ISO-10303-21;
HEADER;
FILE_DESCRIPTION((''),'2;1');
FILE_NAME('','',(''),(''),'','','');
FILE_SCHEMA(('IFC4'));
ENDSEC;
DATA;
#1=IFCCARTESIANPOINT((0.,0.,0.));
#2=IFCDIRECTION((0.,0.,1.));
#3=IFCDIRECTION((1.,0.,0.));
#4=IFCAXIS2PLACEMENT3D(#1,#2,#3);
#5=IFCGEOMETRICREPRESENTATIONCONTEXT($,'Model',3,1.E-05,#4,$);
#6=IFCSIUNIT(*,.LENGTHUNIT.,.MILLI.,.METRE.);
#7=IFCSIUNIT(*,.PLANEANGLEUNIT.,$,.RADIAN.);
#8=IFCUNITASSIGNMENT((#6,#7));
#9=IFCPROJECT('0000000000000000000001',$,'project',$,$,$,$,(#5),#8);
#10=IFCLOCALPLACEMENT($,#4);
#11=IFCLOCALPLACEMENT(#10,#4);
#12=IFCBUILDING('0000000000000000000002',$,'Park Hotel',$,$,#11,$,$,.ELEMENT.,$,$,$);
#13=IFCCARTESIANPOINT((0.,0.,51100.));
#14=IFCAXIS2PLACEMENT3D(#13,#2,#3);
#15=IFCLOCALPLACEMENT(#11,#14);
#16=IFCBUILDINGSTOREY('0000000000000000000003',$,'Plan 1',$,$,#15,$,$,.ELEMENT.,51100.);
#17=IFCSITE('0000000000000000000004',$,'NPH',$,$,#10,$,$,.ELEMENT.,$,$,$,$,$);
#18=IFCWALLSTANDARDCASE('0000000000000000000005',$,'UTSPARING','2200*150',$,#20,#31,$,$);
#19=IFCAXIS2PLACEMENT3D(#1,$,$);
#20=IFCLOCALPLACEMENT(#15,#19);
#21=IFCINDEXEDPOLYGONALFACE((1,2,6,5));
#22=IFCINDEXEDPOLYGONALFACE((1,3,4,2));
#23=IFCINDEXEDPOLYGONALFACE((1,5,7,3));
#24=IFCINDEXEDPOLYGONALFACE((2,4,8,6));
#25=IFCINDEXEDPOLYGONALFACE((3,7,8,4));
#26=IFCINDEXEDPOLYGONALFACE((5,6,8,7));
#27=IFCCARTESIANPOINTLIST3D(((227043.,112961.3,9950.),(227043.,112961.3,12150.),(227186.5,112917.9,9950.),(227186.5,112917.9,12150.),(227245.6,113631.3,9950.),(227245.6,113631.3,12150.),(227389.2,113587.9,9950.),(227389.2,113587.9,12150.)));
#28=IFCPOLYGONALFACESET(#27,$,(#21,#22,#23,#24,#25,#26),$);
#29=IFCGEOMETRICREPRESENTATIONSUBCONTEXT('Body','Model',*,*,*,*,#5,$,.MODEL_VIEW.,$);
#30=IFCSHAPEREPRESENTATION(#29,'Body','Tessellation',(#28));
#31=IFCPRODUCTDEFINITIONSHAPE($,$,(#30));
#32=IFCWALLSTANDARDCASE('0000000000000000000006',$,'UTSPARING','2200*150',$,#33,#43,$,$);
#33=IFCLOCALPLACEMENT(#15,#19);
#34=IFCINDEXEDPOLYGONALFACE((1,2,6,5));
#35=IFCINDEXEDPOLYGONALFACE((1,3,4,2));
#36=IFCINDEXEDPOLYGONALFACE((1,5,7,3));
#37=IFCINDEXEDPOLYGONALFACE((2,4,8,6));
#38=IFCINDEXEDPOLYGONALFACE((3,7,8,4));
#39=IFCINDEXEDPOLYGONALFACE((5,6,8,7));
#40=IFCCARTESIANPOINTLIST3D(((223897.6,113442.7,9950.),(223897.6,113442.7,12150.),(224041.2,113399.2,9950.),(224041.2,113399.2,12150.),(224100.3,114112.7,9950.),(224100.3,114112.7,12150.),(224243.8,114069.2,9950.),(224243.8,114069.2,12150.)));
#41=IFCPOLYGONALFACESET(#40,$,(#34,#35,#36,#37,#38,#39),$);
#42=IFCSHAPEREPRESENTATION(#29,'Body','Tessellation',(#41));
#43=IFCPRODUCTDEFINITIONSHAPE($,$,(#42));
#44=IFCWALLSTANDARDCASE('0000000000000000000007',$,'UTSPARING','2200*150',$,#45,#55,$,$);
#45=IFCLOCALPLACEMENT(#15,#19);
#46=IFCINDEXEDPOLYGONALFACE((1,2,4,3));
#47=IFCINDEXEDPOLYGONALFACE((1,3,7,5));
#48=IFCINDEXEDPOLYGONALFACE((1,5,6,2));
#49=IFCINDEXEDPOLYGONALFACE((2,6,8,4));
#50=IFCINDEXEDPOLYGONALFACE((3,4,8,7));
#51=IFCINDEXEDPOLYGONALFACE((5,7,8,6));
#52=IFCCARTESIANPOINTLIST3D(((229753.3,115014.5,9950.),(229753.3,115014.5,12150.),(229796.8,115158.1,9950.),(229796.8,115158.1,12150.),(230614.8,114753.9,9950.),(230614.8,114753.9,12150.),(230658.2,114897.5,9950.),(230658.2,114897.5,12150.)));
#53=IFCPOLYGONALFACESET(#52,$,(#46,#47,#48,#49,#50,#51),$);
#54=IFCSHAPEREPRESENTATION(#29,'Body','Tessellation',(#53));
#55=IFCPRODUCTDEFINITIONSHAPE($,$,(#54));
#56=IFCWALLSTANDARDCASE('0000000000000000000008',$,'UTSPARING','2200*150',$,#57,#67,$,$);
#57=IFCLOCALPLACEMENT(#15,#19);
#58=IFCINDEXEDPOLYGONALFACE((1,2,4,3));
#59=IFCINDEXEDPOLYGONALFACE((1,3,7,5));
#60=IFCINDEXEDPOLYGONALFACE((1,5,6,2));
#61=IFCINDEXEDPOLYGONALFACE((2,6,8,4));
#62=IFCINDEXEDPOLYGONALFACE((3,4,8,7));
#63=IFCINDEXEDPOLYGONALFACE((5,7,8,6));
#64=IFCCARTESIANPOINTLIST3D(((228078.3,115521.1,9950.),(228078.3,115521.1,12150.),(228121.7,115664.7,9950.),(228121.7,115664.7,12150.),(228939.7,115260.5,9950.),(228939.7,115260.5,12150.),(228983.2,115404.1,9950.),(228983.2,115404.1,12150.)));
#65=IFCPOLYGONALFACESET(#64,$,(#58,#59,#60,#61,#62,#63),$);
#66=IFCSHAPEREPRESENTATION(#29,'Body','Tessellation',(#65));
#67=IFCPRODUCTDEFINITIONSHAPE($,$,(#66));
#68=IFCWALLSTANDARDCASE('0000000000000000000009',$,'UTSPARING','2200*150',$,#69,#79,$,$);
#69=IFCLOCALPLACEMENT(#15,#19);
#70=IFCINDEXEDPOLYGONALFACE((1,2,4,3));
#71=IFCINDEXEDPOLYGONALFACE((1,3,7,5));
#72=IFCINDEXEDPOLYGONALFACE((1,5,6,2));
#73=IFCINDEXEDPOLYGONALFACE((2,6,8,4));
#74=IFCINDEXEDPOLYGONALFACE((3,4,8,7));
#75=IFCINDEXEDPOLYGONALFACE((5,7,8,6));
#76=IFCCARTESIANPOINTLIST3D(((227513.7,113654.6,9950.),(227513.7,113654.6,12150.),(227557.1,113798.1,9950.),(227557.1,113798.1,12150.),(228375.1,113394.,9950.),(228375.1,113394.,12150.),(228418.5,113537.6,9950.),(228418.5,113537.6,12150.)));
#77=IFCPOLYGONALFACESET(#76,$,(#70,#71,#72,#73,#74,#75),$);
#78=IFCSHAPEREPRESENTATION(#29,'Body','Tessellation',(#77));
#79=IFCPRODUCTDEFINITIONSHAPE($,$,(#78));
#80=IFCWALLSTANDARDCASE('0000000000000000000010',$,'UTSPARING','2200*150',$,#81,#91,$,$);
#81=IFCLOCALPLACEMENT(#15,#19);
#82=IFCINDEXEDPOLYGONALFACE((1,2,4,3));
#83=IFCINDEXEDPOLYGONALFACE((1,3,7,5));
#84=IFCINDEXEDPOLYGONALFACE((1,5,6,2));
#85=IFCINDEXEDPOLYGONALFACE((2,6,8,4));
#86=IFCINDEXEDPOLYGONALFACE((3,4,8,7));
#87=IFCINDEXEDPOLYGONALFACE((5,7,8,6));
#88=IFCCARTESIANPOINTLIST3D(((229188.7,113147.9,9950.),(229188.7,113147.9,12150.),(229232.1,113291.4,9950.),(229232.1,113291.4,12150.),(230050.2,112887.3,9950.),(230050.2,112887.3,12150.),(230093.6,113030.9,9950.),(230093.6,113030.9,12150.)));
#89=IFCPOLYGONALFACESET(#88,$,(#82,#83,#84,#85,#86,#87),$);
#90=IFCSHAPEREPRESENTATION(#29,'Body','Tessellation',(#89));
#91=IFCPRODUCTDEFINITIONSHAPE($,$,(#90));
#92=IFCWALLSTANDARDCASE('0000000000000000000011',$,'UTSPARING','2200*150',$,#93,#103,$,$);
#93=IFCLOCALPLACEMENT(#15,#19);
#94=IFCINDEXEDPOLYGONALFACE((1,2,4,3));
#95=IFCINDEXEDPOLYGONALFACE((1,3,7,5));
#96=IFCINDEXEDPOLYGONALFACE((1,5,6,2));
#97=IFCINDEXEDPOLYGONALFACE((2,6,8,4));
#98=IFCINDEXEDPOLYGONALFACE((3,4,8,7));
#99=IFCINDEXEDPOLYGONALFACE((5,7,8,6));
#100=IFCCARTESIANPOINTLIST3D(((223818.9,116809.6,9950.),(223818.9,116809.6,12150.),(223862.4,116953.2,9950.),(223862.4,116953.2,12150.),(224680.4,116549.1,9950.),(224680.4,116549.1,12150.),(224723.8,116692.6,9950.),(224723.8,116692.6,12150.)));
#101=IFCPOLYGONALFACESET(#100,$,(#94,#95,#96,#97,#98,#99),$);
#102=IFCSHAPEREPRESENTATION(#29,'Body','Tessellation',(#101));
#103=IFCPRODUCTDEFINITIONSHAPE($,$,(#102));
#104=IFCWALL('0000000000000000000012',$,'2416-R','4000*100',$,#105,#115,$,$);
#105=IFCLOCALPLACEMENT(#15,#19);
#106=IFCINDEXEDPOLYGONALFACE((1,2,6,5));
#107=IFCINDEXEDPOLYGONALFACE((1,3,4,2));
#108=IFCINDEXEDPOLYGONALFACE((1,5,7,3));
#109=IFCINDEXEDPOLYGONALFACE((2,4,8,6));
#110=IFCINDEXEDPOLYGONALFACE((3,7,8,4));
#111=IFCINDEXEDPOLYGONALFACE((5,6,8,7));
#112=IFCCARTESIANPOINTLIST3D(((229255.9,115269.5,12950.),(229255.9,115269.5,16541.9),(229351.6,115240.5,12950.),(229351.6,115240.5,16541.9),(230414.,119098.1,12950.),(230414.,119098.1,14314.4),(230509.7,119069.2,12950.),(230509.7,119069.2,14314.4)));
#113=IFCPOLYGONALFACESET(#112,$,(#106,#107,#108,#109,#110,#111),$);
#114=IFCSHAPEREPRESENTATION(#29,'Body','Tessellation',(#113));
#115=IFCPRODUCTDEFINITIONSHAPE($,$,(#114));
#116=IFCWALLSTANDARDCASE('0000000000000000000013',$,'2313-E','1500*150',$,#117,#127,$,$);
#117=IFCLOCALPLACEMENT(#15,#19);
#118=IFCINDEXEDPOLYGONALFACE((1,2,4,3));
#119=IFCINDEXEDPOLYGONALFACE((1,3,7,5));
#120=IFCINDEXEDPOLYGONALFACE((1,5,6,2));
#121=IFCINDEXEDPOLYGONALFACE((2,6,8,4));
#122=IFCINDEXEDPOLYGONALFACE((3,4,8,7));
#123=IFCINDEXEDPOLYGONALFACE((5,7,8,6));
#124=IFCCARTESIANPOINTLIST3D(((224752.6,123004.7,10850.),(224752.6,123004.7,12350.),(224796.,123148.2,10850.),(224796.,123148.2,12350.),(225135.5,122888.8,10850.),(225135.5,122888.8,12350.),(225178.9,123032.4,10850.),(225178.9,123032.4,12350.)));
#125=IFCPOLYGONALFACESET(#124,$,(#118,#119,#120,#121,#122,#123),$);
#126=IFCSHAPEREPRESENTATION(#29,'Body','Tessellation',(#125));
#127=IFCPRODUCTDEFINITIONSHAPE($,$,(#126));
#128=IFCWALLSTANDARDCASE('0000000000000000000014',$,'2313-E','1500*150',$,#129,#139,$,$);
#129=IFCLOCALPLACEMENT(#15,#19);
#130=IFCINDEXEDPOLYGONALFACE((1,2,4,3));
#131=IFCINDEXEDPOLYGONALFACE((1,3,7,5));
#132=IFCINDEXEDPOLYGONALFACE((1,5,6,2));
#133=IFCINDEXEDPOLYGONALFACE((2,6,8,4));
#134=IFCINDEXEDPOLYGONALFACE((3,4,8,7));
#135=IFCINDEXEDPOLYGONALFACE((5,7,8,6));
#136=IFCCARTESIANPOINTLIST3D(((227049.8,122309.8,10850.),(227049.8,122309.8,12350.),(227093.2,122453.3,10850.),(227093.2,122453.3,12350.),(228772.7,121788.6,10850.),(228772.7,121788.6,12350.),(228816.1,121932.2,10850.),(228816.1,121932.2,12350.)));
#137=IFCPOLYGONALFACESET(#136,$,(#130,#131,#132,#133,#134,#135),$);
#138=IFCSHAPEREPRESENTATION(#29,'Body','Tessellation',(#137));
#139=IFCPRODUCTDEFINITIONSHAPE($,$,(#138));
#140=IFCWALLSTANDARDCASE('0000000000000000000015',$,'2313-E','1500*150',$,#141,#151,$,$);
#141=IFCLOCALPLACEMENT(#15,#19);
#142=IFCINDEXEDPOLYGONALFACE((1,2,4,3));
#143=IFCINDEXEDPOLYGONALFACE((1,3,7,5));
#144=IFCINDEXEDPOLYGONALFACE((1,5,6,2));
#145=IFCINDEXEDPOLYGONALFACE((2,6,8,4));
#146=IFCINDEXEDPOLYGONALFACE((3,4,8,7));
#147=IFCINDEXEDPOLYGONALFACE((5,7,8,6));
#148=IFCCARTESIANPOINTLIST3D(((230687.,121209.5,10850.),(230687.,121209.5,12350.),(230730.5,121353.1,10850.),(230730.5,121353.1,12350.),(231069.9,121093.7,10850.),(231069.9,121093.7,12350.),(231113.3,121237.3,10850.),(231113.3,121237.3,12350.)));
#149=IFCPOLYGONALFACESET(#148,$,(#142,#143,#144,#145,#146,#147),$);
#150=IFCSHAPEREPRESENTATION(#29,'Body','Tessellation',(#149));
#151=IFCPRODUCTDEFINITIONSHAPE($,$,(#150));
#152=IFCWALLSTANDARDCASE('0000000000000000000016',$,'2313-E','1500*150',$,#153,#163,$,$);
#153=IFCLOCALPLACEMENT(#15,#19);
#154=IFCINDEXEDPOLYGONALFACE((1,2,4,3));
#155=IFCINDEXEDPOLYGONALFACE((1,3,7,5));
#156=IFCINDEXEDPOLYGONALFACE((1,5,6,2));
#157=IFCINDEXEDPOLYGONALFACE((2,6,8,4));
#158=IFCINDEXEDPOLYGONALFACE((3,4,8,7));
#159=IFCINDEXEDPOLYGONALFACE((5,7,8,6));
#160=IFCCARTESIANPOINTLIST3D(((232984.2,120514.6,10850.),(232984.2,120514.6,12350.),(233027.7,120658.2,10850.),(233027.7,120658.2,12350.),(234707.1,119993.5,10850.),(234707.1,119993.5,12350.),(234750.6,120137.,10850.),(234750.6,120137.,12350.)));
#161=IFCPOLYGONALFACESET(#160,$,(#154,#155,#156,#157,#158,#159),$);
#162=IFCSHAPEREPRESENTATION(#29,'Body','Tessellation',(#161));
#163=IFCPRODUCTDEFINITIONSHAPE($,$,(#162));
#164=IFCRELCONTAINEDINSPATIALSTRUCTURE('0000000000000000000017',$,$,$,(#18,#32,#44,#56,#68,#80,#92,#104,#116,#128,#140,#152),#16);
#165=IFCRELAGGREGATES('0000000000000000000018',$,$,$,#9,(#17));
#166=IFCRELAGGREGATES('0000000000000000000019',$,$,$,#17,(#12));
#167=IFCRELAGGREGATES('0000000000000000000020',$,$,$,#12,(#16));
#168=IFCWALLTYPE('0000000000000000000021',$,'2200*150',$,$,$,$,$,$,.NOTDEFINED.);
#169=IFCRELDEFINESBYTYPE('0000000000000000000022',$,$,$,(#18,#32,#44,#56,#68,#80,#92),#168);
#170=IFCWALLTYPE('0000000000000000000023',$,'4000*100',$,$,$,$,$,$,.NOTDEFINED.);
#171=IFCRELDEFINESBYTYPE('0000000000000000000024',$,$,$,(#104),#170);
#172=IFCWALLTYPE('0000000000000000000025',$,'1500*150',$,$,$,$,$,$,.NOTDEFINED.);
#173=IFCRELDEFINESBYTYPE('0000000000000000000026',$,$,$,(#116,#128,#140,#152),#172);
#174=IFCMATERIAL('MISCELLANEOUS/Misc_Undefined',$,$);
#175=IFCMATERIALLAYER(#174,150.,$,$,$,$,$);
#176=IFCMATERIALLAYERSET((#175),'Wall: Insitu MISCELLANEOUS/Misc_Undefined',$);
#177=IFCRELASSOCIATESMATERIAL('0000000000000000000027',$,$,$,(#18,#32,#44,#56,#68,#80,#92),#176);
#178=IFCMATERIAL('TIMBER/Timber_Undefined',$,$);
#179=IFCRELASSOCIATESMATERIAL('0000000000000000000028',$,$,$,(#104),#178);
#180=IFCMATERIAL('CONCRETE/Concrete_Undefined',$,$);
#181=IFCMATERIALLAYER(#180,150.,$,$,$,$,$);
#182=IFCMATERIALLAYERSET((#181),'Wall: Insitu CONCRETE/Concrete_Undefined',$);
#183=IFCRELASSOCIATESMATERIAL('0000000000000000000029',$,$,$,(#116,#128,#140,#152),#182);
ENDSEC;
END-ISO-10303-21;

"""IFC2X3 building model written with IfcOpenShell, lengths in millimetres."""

from ifc_helpers import new_model, si_unit, frame, frame_2d, origin_with_axes, place, context, subcontext, project, spatial, rectangle, extrude, clip, halfspace, material, layer, layer_set, layer_usage, type_object, element, save


model = new_model("IFC2X3")

# Units and contexts
model_context = context("Model", 3, precision=1e-05, world=origin_with_axes())
body_context = subcontext(model_context, "Body", "Model", "MODEL_VIEW")
ifc_project = project(units=[si_unit("LENGTHUNIT", "METRE", prefix="MILLI"), si_unit("PLANEANGLEUNIT", "RADIAN")], contexts=[model_context])

# Site, building, storey
site_placement = place(None, origin_with_axes())
site = spatial("IfcSite", under=ifc_project, at=site_placement, Name="NPH", CompositionType="ELEMENT")
building_placement = place(site_placement, origin_with_axes())
building = spatial("IfcBuilding", under=site, at=building_placement, Name="Park Hotel", CompositionType="ELEMENT")
storey_placement = place(building_placement, frame((0.0, 0.0, 51100.0), z_axis=(0.0, 0.0, 1.0), x_axis=(1.0, 0.0, 0.0)))
storey = spatial("IfcBuildingStorey", under=building, at=storey_placement, Name="Plan 1", CompositionType="ELEMENT", Elevation=51100.0)

# Shared definitions
ifc_material_1 = material(Name="TIMBER/Timber_Undefined")

# Walls
ifc_material_2 = material(Name="CONCRETE/Concrete_Undefined")
ifc_material_3 = material(Name="MISCELLANEOUS/Misc_Undefined")
ifc_layer_1 = layer(ifc_material_3, 150.0)
ifc_layer_set_1 = layer_set([ifc_layer_1], Name="Wall: Insitu MISCELLANEOUS/Misc_Undefined")
wall_type_1 = type_object("IfcWallType", Name="2200*150", PredefinedType="NOTDEFINED")
ifc_layer_usage_1 = layer_usage(ifc_layer_set_1, "AXIS2", "POSITIVE", -75.0)
wall_1_placement = place(storey_placement, frame((227114.7, 112939.6, 9950.0), z_axis=(0.0, 0.0, 1.0), x_axis=(0.289542, 0.957165, 0.0)))
element("IfcWallStandardCase", 1, at=wall_1_placement, inside=storey, type_object=wall_type_1, material=ifc_layer_usage_1, Name="UTSPARING", Description="2200*150", context=body_context, shape_type="SweptSolid", body=[
    extrude(rectangle(XDim=700.0, YDim=150.0, at=frame_2d((0.0, 350.0), x_axis=(0.0, -1.0))), frame((0.0, 0.0, 0.0), z_axis=(0.0, 0.0, 1.0), x_axis=(0.0, -1.0, 0.0)), (0.0, 0.0, 1.0), 2200.0),
])
ifc_layer_usage_2 = layer_usage(ifc_layer_set_1, "AXIS2", "POSITIVE", -75.0)
wall_2_placement = place(storey_placement, frame((223969.4, 113420.9, 9950.0), z_axis=(0.0, 0.0, 1.0), x_axis=(0.289542, 0.957165, 0.0)))
element("IfcWallStandardCase", 2, at=wall_2_placement, inside=storey, type_object=wall_type_1, material=ifc_layer_usage_2, Name="UTSPARING", Description="2200*150", context=body_context, shape_type="SweptSolid", body=[
    extrude(rectangle(XDim=700.0, YDim=150.0, at=frame_2d((0.0, 350.0), x_axis=(0.0, -1.0))), frame((0.0, 0.0, 0.0), z_axis=(0.0, 0.0, 1.0), x_axis=(0.0, -1.0, 0.0)), (0.0, 0.0, 1.0), 2200.0),
])
ifc_layer_usage_3 = layer_usage(ifc_layer_set_1, "AXIS2", "POSITIVE", -75.0)
wall_3_placement = place(storey_placement, frame((229775.1, 115086.3, 9950.0), z_axis=(0.0, 0.0, 1.0), x_axis=(0.957166, -0.289541, 0.0)))
element("IfcWallStandardCase", 3, at=wall_3_placement, inside=storey, type_object=wall_type_1, material=ifc_layer_usage_3, Name="UTSPARING", Description="2200*150", context=body_context, shape_type="SweptSolid", body=[
    extrude(rectangle(XDim=900.0, YDim=150.0, at=frame_2d((0.0, 450.0), x_axis=(0.0, -1.0))), frame((0.0, 0.0, 0.0), z_axis=(0.0, 0.0, 1.0), x_axis=(0.0, -1.0, 0.0)), (0.0, 0.0, 1.0), 2200.0),
])
ifc_layer_usage_4 = layer_usage(ifc_layer_set_1, "AXIS2", "POSITIVE", -75.0)
wall_4_placement = place(storey_placement, frame((228100.0, 115592.9, 9950.0), z_axis=(0.0, 0.0, 1.0), x_axis=(0.957166, -0.289541, 0.0)))
element("IfcWallStandardCase", 4, at=wall_4_placement, inside=storey, type_object=wall_type_1, material=ifc_layer_usage_4, Name="UTSPARING", Description="2200*150", context=body_context, shape_type="SweptSolid", body=[
    extrude(rectangle(XDim=900.0, YDim=150.0, at=frame_2d((0.0, 450.0), x_axis=(0.0, -1.0))), frame((0.0, 0.0, 0.0), z_axis=(0.0, 0.0, 1.0), x_axis=(0.0, -1.0, 0.0)), (0.0, 0.0, 1.0), 2200.0),
])
ifc_layer_usage_5 = layer_usage(ifc_layer_set_1, "AXIS2", "POSITIVE", -75.0)
wall_5_placement = place(storey_placement, frame((227535.4, 113726.4, 9950.0), z_axis=(0.0, 0.0, 1.0), x_axis=(0.957166, -0.289541, 0.0)))
element("IfcWallStandardCase", 5, at=wall_5_placement, inside=storey, type_object=wall_type_1, material=ifc_layer_usage_5, Name="UTSPARING", Description="2200*150", context=body_context, shape_type="SweptSolid", body=[
    extrude(rectangle(XDim=900.0, YDim=150.0, at=frame_2d((0.0, 450.0), x_axis=(0.0, -1.0))), frame((0.0, 0.0, 0.0), z_axis=(0.0, 0.0, 1.0), x_axis=(0.0, -1.0, 0.0)), (0.0, 0.0, 1.0), 2200.0),
])
ifc_layer_usage_6 = layer_usage(ifc_layer_set_1, "AXIS2", "POSITIVE", -75.0)
wall_6_placement = place(storey_placement, frame((229210.4, 113219.7, 9950.0), z_axis=(0.0, 0.0, 1.0), x_axis=(0.957166, -0.289541, 0.0)))
element("IfcWallStandardCase", 6, at=wall_6_placement, inside=storey, type_object=wall_type_1, material=ifc_layer_usage_6, Name="UTSPARING", Description="2200*150", context=body_context, shape_type="SweptSolid", body=[
    extrude(rectangle(XDim=900.0, YDim=150.0, at=frame_2d((0.0, 450.0), x_axis=(0.0, -1.0))), frame((0.0, 0.0, 0.0), z_axis=(0.0, 0.0, 1.0), x_axis=(0.0, -1.0, 0.0)), (0.0, 0.0, 1.0), 2200.0),
])
ifc_layer_usage_7 = layer_usage(ifc_layer_set_1, "AXIS2", "POSITIVE", -75.0)
wall_7_placement = place(storey_placement, frame((223840.6, 116881.4, 9950.0), z_axis=(0.0, 0.0, 1.0), x_axis=(0.957166, -0.289541, 0.0)))
element("IfcWallStandardCase", 7, at=wall_7_placement, inside=storey, type_object=wall_type_1, material=ifc_layer_usage_7, Name="UTSPARING", Description="2200*150", context=body_context, shape_type="SweptSolid", body=[
    extrude(rectangle(XDim=900.0, YDim=150.0, at=frame_2d((0.0, 450.0), x_axis=(0.0, -1.0))), frame((0.0, 0.0, 0.0), z_axis=(0.0, 0.0, 1.0), x_axis=(0.0, -1.0, 0.0)), (0.0, 0.0, 1.0), 2200.0),
])
wall_type_2 = type_object("IfcWallType", Name="4000*100", PredefinedType="NOTDEFINED")
wall_8_placement = place(storey_placement, frame((229303.7, 115255.0, 13154.0), z_axis=(0.0, 0.0, 1.0), x_axis=(0.289539, 0.957166, 0.0)))
element("IfcWall", 8, at=wall_8_placement, inside=storey, type_object=wall_type_2, material=ifc_material_1, Name="2416-R", Description="4000*100", context=body_context, shape_type="Clipping", body=[
    clip(extrude(rectangle(XDim=4000.0, YDim=100.0, at=frame_2d((0.0, 2000.0), x_axis=(0.0, -1.0))), frame((0.0, 0.0, -204.1), z_axis=(0.0, 0.0, 1.0), x_axis=(0.0, -1.0, 0.0)), (0.0, 0.0, 1.0), 4000.0), halfspace(frame((-732.8, 50.0, 3795.9), z_axis=(0.486531, 0.000001, 0.873663), x_axis=(0.873663, 0.0, -0.486531)), False)),
])
ifc_layer_2 = layer(ifc_material_2, 150.0)
ifc_layer_set_2 = layer_set([ifc_layer_2], Name="Wall: Insitu CONCRETE/Concrete_Undefined")
ifc_layer_usage_8 = layer_usage(ifc_layer_set_2, "AXIS2", "POSITIVE", -75.0)
wall_type_3 = type_object("IfcWallType", Name="1500*150", PredefinedType="NOTDEFINED")
wall_9_placement = place(storey_placement, frame((224774.3, 123076.5, 10850.0), z_axis=(0.0, 0.0, 1.0), x_axis=(0.957161, -0.289556, 0.0)))
element("IfcWallStandardCase", 9, at=wall_9_placement, inside=storey, type_object=wall_type_3, material=ifc_layer_usage_8, Name="2313-E", Description="1500*150", context=body_context, shape_type="SweptSolid", body=[
    extrude(rectangle(XDim=400.0, YDim=150.0, at=frame_2d((0.0, 200.0), x_axis=(0.0, -1.0))), frame((0.0, 0.0, 0.0), z_axis=(0.0, 0.0, 1.0), x_axis=(0.0, -1.0, 0.0)), (0.0, 0.0, 1.0), 1500.0),
])
ifc_layer_usage_9 = layer_usage(ifc_layer_set_2, "AXIS2", "POSITIVE", -75.0)
wall_10_placement = place(storey_placement, frame((227071.5, 122381.6, 10850.0), z_axis=(0.0, 0.0, 1.0), x_axis=(0.957166, -0.289541, 0.0)))
element("IfcWallStandardCase", 10, at=wall_10_placement, inside=storey, type_object=wall_type_3, material=ifc_layer_usage_9, Name="2313-E", Description="1500*150", context=body_context, shape_type="SweptSolid", body=[
    extrude(rectangle(XDim=1800.0, YDim=150.0, at=frame_2d((0.0, 900.0), x_axis=(0.0, -1.0))), frame((0.0, 0.0, 0.0), z_axis=(0.0, 0.0, 1.0), x_axis=(0.0, -1.0, 0.0)), (0.0, 0.0, 1.0), 1500.0),
])
ifc_layer_usage_10 = layer_usage(ifc_layer_set_2, "AXIS2", "POSITIVE", -75.0)
wall_11_placement = place(storey_placement, frame((230708.8, 121281.3, 10850.0), z_axis=(0.0, 0.0, 1.0), x_axis=(0.957161, -0.289556, 0.0)))
element("IfcWallStandardCase", 11, at=wall_11_placement, inside=storey, type_object=wall_type_3, material=ifc_layer_usage_10, Name="2313-E", Description="1500*150", context=body_context, shape_type="SweptSolid", body=[
    extrude(rectangle(XDim=400.0, YDim=150.0, at=frame_2d((0.0, 200.0), x_axis=(0.0, -1.0))), frame((0.0, 0.0, 0.0), z_axis=(0.0, 0.0, 1.0), x_axis=(0.0, -1.0, 0.0)), (0.0, 0.0, 1.0), 1500.0),
])
ifc_layer_usage_11 = layer_usage(ifc_layer_set_2, "AXIS2", "POSITIVE", -75.0)
wall_12_placement = place(storey_placement, frame((233006.0, 120586.4, 10850.0), z_axis=(0.0, 0.0, 1.0), x_axis=(0.957166, -0.289541, 0.0)))
element("IfcWallStandardCase", 12, at=wall_12_placement, inside=storey, type_object=wall_type_3, material=ifc_layer_usage_11, Name="2313-E", Description="1500*150", context=body_context, shape_type="SweptSolid", body=[
    extrude(rectangle(XDim=1800.0, YDim=150.0, at=frame_2d((0.0, 900.0), x_axis=(0.0, -1.0))), frame((0.0, 0.0, 0.0), z_axis=(0.0, 0.0, 1.0), x_axis=(0.0, -1.0, 0.0)), (0.0, 0.0, 1.0), 1500.0),
])

save(model, "model.ifc")
